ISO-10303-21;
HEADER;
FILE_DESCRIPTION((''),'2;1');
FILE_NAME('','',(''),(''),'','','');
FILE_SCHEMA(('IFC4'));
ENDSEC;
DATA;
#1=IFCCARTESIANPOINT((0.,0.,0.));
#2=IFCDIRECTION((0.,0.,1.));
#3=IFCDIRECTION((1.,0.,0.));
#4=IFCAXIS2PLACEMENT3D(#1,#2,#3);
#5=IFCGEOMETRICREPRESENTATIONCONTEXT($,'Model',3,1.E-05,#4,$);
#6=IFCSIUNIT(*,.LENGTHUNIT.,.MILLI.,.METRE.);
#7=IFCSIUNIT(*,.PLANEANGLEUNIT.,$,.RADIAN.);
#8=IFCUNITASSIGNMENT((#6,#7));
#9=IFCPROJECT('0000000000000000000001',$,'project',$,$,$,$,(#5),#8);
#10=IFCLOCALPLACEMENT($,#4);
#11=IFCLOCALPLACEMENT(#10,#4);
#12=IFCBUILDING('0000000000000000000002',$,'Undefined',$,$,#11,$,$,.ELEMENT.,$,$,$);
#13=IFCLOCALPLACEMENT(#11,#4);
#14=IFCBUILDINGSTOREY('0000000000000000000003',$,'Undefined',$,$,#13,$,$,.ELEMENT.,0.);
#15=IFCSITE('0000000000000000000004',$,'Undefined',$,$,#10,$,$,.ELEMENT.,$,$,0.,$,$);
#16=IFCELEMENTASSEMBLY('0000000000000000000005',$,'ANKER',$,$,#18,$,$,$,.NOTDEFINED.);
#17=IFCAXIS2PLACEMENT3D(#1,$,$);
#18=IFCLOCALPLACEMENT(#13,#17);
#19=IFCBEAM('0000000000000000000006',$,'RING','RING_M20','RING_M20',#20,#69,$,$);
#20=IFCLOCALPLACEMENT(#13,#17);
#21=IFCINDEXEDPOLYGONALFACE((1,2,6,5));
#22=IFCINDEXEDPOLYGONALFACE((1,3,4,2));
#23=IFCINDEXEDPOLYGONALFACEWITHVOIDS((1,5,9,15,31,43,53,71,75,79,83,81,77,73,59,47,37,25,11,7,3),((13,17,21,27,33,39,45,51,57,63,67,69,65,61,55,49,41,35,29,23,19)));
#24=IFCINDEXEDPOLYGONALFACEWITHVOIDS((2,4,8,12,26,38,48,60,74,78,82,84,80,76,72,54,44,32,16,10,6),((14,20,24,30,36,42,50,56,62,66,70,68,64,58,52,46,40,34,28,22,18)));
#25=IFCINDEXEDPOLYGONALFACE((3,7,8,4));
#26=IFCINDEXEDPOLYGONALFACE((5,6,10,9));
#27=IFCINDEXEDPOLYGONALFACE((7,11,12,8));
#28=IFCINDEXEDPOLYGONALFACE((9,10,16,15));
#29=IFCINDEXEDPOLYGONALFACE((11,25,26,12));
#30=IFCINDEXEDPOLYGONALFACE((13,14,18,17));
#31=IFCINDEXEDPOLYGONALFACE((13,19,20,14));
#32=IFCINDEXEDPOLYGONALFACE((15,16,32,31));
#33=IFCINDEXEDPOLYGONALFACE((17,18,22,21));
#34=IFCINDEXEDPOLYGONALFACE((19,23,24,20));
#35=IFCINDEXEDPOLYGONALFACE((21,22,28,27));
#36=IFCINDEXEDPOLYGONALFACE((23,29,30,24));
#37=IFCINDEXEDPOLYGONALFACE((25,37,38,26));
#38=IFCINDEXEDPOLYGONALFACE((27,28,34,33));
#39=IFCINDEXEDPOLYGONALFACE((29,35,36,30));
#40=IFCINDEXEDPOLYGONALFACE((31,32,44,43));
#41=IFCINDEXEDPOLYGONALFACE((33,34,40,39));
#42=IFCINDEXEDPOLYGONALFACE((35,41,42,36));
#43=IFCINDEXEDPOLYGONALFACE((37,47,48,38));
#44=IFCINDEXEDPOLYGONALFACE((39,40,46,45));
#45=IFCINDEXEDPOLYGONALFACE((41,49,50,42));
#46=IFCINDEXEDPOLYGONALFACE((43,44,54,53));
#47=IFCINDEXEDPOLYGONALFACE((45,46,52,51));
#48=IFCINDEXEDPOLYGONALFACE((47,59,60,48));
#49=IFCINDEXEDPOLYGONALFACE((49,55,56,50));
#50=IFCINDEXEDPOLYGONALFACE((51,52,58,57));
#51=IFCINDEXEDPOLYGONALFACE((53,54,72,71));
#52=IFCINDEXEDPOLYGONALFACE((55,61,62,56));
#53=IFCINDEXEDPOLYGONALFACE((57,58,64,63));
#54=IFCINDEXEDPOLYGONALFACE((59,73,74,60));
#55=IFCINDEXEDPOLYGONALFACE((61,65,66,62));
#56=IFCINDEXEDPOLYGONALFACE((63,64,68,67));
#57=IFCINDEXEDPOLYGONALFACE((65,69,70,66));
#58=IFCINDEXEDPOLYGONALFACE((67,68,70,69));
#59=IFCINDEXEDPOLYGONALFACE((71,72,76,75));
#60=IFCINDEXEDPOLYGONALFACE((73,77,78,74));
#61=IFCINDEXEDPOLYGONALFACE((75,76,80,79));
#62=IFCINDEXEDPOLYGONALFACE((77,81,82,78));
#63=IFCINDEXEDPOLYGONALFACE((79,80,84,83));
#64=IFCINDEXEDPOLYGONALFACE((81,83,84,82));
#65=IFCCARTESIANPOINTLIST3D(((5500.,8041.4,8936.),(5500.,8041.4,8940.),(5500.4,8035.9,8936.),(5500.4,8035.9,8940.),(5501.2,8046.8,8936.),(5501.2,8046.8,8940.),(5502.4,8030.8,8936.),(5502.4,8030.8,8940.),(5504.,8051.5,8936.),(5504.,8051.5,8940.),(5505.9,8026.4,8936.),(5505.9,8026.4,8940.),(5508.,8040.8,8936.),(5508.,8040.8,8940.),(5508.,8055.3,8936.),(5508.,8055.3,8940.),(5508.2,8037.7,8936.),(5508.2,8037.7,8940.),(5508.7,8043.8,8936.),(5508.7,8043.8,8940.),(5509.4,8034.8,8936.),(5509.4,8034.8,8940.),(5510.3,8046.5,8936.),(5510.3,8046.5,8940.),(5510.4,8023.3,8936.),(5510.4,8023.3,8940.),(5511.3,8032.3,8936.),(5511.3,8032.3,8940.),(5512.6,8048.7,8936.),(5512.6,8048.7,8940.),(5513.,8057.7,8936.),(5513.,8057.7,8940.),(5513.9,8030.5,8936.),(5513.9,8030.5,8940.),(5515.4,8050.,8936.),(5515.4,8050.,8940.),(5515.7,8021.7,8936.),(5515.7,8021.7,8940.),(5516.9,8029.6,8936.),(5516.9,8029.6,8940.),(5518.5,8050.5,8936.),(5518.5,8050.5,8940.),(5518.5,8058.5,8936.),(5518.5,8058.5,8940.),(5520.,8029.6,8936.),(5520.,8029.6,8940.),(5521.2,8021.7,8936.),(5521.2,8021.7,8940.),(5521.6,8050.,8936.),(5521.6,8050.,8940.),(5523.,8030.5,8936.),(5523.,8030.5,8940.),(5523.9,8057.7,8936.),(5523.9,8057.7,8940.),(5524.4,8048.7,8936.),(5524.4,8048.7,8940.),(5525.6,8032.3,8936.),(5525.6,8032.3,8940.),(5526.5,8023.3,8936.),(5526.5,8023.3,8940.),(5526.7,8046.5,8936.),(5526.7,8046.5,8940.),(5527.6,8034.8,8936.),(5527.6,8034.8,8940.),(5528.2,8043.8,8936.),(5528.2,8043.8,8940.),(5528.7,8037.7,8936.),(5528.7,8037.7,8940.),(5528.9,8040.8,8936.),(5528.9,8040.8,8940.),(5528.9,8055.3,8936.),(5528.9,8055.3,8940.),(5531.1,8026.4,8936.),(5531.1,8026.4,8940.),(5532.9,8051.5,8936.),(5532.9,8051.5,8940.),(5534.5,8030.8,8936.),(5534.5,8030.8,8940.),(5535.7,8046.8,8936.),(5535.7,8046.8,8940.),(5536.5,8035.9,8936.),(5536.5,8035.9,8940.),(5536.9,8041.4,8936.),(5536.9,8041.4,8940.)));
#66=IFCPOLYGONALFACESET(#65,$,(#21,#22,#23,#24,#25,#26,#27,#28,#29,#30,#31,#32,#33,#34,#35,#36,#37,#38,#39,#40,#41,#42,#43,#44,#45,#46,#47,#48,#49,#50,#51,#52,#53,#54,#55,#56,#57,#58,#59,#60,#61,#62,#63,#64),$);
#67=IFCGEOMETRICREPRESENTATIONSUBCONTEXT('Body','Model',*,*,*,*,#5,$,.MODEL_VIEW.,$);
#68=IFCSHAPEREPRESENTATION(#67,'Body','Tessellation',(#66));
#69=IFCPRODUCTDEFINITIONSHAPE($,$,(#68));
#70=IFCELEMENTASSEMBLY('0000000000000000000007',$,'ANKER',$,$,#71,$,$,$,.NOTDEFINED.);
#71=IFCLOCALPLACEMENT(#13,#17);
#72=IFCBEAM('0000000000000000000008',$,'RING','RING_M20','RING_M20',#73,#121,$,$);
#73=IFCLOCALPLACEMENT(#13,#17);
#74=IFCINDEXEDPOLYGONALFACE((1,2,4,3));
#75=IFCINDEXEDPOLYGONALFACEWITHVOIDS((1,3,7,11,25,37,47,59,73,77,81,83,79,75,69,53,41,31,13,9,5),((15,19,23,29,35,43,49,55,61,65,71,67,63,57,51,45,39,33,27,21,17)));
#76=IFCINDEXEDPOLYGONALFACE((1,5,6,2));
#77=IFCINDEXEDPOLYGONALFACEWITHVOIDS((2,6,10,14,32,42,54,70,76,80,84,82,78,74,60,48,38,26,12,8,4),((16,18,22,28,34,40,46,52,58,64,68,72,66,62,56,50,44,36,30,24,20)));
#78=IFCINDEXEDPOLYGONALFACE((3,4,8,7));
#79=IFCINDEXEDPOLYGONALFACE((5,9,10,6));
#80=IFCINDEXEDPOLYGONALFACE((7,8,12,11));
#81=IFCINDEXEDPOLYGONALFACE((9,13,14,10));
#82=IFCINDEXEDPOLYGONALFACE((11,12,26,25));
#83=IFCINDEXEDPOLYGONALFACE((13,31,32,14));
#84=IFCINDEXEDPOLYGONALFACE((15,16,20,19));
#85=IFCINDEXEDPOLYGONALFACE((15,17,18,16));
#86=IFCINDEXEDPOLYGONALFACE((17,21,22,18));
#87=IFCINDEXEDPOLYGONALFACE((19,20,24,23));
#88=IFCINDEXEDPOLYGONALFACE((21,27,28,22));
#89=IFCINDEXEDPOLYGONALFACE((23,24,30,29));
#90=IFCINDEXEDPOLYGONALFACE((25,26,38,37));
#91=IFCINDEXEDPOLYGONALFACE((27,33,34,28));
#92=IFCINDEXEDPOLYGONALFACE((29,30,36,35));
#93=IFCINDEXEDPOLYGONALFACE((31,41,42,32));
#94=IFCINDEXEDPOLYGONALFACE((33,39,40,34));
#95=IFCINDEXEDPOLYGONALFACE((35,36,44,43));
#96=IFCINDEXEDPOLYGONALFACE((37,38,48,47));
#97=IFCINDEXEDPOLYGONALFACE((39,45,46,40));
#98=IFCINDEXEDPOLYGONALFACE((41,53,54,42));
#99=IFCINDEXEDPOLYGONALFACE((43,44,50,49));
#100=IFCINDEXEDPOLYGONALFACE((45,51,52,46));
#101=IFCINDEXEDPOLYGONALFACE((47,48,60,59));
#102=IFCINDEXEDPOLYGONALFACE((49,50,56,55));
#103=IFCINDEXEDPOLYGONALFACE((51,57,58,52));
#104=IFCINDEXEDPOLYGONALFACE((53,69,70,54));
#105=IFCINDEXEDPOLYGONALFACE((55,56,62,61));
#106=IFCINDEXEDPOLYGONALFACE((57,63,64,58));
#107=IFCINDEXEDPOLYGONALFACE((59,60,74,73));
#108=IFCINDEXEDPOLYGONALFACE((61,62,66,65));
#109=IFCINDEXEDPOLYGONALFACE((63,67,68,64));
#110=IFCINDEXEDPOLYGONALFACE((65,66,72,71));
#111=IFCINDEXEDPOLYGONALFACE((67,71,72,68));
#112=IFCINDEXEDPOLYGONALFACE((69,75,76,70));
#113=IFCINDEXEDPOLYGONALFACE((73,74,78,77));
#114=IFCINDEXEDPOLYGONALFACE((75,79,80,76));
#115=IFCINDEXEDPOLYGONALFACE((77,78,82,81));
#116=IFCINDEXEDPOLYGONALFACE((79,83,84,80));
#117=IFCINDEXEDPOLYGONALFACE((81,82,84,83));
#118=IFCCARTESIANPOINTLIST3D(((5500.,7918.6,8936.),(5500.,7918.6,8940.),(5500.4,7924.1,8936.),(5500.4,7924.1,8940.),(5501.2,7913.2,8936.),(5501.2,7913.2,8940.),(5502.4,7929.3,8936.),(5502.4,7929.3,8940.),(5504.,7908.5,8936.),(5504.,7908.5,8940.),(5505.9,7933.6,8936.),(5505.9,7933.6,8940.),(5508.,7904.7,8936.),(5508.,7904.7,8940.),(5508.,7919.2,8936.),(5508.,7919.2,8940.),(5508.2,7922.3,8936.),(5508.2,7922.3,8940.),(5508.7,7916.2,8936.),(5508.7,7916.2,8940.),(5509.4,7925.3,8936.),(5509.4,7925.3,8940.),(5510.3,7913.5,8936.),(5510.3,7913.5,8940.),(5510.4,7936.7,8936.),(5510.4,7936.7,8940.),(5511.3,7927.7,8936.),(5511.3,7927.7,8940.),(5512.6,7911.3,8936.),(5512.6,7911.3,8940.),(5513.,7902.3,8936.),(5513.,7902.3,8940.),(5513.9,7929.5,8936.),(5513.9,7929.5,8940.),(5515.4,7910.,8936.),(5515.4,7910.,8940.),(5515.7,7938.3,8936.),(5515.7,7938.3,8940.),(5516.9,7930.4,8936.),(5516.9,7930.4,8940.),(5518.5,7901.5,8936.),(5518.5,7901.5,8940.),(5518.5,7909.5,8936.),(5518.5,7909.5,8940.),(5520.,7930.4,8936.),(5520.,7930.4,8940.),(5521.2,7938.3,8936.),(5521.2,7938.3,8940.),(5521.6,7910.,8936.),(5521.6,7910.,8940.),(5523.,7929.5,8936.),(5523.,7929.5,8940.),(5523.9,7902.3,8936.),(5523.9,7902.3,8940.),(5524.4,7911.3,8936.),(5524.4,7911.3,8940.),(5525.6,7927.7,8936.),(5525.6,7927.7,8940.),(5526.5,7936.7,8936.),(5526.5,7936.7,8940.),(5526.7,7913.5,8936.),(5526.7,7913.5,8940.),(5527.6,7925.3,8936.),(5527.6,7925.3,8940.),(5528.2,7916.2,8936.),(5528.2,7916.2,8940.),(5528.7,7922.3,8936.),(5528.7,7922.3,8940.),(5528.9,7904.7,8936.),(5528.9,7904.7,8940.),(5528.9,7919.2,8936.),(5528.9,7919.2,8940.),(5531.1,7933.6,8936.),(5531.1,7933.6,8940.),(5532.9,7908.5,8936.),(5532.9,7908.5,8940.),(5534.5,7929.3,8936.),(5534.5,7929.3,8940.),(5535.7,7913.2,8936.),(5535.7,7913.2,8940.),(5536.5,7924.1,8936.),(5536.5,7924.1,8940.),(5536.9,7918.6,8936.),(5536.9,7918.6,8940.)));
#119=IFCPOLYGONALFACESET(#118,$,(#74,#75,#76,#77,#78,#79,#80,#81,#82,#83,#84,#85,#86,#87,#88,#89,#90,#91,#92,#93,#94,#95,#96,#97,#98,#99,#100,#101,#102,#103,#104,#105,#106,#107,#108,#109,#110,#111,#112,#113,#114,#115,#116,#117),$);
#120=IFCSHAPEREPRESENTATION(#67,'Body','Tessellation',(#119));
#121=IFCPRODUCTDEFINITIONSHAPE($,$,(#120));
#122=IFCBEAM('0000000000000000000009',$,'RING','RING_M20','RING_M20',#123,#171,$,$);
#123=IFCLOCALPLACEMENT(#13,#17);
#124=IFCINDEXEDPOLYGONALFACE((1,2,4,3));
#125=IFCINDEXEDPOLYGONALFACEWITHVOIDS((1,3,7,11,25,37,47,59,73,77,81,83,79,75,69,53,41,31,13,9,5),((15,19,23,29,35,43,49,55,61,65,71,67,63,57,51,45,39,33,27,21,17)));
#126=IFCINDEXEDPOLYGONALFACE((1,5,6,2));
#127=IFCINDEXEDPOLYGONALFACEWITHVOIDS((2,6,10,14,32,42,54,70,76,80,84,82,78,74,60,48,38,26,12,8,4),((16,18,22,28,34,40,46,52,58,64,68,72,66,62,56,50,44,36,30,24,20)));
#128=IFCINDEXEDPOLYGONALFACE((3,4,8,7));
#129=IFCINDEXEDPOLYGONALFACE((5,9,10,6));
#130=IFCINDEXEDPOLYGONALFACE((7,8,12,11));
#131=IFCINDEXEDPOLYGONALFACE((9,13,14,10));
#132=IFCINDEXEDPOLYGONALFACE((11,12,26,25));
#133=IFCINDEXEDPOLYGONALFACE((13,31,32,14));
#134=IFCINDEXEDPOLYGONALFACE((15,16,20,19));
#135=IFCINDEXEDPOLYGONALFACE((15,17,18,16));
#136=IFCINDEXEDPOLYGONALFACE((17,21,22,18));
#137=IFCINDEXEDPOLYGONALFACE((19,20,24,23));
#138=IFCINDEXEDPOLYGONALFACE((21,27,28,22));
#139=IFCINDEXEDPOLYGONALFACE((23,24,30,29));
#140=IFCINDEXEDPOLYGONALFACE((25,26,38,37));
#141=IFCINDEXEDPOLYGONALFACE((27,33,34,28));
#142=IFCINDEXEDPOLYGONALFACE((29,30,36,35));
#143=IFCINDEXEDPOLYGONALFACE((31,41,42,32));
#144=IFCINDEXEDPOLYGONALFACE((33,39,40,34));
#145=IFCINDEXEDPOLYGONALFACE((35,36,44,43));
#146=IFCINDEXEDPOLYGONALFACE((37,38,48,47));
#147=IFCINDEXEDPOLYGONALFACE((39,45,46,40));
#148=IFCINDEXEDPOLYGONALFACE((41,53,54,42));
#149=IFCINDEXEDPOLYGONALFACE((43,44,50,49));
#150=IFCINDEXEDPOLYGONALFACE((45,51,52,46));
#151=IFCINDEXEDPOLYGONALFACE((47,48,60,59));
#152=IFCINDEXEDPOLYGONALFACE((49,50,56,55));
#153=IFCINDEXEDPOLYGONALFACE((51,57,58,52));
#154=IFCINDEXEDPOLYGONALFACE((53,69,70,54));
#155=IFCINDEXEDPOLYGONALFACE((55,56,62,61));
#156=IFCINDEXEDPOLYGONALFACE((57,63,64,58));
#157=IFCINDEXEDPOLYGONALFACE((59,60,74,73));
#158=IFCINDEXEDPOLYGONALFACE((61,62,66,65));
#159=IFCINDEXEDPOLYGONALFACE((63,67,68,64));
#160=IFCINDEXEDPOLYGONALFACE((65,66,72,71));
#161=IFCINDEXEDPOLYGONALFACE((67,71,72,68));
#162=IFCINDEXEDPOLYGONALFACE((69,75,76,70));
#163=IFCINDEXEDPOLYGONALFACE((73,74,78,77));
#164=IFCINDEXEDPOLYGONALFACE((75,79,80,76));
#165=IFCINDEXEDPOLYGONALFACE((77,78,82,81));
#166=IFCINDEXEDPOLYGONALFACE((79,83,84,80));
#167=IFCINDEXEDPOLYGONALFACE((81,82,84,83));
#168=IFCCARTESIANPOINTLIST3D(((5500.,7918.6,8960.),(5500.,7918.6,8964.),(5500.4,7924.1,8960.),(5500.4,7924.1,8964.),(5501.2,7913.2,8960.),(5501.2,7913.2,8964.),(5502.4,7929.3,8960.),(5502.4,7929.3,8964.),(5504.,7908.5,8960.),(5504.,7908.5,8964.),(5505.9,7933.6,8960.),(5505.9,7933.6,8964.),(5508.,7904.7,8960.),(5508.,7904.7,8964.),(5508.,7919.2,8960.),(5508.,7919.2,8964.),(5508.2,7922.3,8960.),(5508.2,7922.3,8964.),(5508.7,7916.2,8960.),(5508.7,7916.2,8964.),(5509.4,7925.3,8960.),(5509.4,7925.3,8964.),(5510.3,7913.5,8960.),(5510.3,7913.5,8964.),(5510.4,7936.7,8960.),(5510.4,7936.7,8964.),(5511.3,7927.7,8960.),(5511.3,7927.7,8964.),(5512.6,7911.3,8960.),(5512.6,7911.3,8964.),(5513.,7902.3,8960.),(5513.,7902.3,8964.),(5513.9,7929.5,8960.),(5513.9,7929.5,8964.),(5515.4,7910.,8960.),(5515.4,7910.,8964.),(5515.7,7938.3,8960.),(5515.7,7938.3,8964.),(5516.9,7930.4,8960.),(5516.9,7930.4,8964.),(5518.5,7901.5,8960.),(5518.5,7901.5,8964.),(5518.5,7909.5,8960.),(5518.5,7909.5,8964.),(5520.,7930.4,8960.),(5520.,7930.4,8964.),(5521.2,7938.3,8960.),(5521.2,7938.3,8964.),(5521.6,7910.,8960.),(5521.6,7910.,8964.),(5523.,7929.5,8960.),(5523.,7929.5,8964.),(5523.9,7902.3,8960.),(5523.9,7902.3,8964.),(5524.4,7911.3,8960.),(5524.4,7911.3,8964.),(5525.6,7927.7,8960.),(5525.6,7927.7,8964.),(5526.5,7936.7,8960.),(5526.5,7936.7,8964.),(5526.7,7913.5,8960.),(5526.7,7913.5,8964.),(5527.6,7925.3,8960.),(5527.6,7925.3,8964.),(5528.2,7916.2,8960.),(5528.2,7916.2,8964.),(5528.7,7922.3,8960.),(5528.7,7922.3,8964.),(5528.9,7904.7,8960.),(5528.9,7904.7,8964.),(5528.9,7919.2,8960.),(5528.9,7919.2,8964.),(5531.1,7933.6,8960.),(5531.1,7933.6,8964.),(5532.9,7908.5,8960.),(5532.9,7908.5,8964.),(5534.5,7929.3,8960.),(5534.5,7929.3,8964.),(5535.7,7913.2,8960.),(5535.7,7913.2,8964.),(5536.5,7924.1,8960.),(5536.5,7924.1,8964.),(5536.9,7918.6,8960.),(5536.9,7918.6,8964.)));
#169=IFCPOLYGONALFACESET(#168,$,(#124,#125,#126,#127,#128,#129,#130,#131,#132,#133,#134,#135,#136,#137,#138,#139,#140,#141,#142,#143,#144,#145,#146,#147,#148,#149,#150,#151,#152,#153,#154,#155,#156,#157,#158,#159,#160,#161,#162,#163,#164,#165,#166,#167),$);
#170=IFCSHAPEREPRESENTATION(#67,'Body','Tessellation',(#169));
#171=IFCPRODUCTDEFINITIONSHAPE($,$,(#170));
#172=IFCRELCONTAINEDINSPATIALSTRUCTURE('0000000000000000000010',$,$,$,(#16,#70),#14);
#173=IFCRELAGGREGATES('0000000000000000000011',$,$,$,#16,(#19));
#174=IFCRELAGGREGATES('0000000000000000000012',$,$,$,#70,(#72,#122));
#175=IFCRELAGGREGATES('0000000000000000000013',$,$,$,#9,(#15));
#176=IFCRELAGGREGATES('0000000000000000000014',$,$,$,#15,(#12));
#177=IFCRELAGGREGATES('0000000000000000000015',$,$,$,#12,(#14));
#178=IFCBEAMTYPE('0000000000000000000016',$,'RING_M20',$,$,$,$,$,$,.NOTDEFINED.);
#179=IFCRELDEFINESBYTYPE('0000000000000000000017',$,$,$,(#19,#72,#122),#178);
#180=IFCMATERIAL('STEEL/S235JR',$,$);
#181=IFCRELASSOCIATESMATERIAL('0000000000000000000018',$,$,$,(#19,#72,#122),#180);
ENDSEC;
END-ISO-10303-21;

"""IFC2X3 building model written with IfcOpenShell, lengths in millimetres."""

from ifc_helpers import new_model, si_unit, frame, origin_with_axes, origin_2d_with_axis, place, context, subcontext, project, spatial, hollow_circle, extrude, material, type_object, element, aggregate, save


model = new_model("IFC2X3")

# Units and contexts
model_context = context("Model", 3, precision=1e-05, world=origin_with_axes())
body_context = subcontext(model_context, "Body", "Model", "MODEL_VIEW")
ifc_project = project(units=[si_unit("LENGTHUNIT", "METRE", prefix="MILLI"), si_unit("PLANEANGLEUNIT", "RADIAN")], contexts=[model_context])

# Site, building, storey
site_placement = place(None, origin_with_axes())
site = spatial("IfcSite", under=ifc_project, at=site_placement, Name="Undefined", CompositionType="ELEMENT", RefElevation=0.0)
building_placement = place(site_placement, origin_with_axes())
building = spatial("IfcBuilding", under=site, at=building_placement, Name="Undefined", CompositionType="ELEMENT")
storey_placement = place(building_placement, origin_with_axes())
storey = spatial("IfcBuildingStorey", under=building, at=storey_placement, Name="Undefined", CompositionType="ELEMENT", Elevation=0.0)

# Shared definitions
ifc_material = material(Name="STEEL/S235JR")

# Element assembly, beam
assembly_1_placement = place(storey_placement, frame((5518.5, 8040.0, 9010.0), z_axis=(0.0, 1.0, 0.0), x_axis=(0.0, 0.0, -1.0)))
assembly_1 = element("IfcElementAssembly", 1, at=assembly_1_placement, inside=storey, Name="ANKER", PredefinedType="NOTDEFINED")
beam_type_1 = type_object("IfcBeamType", Name="RING_M20", PredefinedType="NOTDEFINED")
beam_1_placement = place(storey_placement, frame((5518.5, 8040.0, 8940.0), z_axis=(-1.0, 0.0, 0.0), x_axis=(0.0, 0.0, -1.0)))
beam_1 = element("IfcBeam", 2, at=beam_1_placement, type_object=beam_type_1, material=ifc_material, Name="RING", Description="RING_M20", ObjectType="RING_M20", context=body_context, shape_type="SweptSolid", body=[
    extrude(hollow_circle(Radius=18.5, WallThickness=8.0, at=origin_2d_with_axis()), frame((4.0, 0.0, 0.0), z_axis=(-1.0, 0.0, 0.0), x_axis=(0.0, -1.0, 0.0)), (0.0, 0.0, 1.0), 4.0),
])
aggregate(assembly_1, [beam_1])

# Element assembly, beams
assembly_2_placement = place(storey_placement, frame((5518.5, 7920.0, 9010.0), z_axis=(0.0, 1.0, 0.0), x_axis=(0.0, 0.0, -1.0)))
assembly_2 = element("IfcElementAssembly", 3, at=assembly_2_placement, inside=storey, Name="ANKER", PredefinedType="NOTDEFINED")
beam_2_placement = place(storey_placement, frame((5518.5, 7920.0, 8940.0), z_axis=(1.0, 0.0, 0.0), x_axis=(0.0, 0.0, -1.0)))
beam_2 = element("IfcBeam", 4, at=beam_2_placement, type_object=beam_type_1, material=ifc_material, Name="RING", Description="RING_M20", ObjectType="RING_M20", context=body_context, shape_type="SweptSolid", body=[
    extrude(hollow_circle(Radius=18.5, WallThickness=8.0, at=origin_2d_with_axis()), frame((4.0, 0.0, 0.0), z_axis=(-1.0, 0.0, 0.0), x_axis=(0.0, -1.0, 0.0)), (0.0, 0.0, 1.0), 4.0),
])
beam_3_placement = place(storey_placement, frame((5518.5, 7920.0, 8964.0), z_axis=(1.0, 0.0, 0.0), x_axis=(0.0, 0.0, -1.0)))
beam_3 = element("IfcBeam", 5, at=beam_3_placement, type_object=beam_type_1, material=ifc_material, Name="RING", Description="RING_M20", ObjectType="RING_M20", context=body_context, shape_type="SweptSolid", body=[
    extrude(hollow_circle(Radius=18.5, WallThickness=8.0, at=origin_2d_with_axis()), frame((4.0, 0.0, 0.0), z_axis=(-1.0, 0.0, 0.0), x_axis=(0.0, -1.0, 0.0)), (0.0, 0.0, 1.0), 4.0),
])
aggregate(assembly_2, [beam_2, beam_3])

save(model, "model.ifc")
